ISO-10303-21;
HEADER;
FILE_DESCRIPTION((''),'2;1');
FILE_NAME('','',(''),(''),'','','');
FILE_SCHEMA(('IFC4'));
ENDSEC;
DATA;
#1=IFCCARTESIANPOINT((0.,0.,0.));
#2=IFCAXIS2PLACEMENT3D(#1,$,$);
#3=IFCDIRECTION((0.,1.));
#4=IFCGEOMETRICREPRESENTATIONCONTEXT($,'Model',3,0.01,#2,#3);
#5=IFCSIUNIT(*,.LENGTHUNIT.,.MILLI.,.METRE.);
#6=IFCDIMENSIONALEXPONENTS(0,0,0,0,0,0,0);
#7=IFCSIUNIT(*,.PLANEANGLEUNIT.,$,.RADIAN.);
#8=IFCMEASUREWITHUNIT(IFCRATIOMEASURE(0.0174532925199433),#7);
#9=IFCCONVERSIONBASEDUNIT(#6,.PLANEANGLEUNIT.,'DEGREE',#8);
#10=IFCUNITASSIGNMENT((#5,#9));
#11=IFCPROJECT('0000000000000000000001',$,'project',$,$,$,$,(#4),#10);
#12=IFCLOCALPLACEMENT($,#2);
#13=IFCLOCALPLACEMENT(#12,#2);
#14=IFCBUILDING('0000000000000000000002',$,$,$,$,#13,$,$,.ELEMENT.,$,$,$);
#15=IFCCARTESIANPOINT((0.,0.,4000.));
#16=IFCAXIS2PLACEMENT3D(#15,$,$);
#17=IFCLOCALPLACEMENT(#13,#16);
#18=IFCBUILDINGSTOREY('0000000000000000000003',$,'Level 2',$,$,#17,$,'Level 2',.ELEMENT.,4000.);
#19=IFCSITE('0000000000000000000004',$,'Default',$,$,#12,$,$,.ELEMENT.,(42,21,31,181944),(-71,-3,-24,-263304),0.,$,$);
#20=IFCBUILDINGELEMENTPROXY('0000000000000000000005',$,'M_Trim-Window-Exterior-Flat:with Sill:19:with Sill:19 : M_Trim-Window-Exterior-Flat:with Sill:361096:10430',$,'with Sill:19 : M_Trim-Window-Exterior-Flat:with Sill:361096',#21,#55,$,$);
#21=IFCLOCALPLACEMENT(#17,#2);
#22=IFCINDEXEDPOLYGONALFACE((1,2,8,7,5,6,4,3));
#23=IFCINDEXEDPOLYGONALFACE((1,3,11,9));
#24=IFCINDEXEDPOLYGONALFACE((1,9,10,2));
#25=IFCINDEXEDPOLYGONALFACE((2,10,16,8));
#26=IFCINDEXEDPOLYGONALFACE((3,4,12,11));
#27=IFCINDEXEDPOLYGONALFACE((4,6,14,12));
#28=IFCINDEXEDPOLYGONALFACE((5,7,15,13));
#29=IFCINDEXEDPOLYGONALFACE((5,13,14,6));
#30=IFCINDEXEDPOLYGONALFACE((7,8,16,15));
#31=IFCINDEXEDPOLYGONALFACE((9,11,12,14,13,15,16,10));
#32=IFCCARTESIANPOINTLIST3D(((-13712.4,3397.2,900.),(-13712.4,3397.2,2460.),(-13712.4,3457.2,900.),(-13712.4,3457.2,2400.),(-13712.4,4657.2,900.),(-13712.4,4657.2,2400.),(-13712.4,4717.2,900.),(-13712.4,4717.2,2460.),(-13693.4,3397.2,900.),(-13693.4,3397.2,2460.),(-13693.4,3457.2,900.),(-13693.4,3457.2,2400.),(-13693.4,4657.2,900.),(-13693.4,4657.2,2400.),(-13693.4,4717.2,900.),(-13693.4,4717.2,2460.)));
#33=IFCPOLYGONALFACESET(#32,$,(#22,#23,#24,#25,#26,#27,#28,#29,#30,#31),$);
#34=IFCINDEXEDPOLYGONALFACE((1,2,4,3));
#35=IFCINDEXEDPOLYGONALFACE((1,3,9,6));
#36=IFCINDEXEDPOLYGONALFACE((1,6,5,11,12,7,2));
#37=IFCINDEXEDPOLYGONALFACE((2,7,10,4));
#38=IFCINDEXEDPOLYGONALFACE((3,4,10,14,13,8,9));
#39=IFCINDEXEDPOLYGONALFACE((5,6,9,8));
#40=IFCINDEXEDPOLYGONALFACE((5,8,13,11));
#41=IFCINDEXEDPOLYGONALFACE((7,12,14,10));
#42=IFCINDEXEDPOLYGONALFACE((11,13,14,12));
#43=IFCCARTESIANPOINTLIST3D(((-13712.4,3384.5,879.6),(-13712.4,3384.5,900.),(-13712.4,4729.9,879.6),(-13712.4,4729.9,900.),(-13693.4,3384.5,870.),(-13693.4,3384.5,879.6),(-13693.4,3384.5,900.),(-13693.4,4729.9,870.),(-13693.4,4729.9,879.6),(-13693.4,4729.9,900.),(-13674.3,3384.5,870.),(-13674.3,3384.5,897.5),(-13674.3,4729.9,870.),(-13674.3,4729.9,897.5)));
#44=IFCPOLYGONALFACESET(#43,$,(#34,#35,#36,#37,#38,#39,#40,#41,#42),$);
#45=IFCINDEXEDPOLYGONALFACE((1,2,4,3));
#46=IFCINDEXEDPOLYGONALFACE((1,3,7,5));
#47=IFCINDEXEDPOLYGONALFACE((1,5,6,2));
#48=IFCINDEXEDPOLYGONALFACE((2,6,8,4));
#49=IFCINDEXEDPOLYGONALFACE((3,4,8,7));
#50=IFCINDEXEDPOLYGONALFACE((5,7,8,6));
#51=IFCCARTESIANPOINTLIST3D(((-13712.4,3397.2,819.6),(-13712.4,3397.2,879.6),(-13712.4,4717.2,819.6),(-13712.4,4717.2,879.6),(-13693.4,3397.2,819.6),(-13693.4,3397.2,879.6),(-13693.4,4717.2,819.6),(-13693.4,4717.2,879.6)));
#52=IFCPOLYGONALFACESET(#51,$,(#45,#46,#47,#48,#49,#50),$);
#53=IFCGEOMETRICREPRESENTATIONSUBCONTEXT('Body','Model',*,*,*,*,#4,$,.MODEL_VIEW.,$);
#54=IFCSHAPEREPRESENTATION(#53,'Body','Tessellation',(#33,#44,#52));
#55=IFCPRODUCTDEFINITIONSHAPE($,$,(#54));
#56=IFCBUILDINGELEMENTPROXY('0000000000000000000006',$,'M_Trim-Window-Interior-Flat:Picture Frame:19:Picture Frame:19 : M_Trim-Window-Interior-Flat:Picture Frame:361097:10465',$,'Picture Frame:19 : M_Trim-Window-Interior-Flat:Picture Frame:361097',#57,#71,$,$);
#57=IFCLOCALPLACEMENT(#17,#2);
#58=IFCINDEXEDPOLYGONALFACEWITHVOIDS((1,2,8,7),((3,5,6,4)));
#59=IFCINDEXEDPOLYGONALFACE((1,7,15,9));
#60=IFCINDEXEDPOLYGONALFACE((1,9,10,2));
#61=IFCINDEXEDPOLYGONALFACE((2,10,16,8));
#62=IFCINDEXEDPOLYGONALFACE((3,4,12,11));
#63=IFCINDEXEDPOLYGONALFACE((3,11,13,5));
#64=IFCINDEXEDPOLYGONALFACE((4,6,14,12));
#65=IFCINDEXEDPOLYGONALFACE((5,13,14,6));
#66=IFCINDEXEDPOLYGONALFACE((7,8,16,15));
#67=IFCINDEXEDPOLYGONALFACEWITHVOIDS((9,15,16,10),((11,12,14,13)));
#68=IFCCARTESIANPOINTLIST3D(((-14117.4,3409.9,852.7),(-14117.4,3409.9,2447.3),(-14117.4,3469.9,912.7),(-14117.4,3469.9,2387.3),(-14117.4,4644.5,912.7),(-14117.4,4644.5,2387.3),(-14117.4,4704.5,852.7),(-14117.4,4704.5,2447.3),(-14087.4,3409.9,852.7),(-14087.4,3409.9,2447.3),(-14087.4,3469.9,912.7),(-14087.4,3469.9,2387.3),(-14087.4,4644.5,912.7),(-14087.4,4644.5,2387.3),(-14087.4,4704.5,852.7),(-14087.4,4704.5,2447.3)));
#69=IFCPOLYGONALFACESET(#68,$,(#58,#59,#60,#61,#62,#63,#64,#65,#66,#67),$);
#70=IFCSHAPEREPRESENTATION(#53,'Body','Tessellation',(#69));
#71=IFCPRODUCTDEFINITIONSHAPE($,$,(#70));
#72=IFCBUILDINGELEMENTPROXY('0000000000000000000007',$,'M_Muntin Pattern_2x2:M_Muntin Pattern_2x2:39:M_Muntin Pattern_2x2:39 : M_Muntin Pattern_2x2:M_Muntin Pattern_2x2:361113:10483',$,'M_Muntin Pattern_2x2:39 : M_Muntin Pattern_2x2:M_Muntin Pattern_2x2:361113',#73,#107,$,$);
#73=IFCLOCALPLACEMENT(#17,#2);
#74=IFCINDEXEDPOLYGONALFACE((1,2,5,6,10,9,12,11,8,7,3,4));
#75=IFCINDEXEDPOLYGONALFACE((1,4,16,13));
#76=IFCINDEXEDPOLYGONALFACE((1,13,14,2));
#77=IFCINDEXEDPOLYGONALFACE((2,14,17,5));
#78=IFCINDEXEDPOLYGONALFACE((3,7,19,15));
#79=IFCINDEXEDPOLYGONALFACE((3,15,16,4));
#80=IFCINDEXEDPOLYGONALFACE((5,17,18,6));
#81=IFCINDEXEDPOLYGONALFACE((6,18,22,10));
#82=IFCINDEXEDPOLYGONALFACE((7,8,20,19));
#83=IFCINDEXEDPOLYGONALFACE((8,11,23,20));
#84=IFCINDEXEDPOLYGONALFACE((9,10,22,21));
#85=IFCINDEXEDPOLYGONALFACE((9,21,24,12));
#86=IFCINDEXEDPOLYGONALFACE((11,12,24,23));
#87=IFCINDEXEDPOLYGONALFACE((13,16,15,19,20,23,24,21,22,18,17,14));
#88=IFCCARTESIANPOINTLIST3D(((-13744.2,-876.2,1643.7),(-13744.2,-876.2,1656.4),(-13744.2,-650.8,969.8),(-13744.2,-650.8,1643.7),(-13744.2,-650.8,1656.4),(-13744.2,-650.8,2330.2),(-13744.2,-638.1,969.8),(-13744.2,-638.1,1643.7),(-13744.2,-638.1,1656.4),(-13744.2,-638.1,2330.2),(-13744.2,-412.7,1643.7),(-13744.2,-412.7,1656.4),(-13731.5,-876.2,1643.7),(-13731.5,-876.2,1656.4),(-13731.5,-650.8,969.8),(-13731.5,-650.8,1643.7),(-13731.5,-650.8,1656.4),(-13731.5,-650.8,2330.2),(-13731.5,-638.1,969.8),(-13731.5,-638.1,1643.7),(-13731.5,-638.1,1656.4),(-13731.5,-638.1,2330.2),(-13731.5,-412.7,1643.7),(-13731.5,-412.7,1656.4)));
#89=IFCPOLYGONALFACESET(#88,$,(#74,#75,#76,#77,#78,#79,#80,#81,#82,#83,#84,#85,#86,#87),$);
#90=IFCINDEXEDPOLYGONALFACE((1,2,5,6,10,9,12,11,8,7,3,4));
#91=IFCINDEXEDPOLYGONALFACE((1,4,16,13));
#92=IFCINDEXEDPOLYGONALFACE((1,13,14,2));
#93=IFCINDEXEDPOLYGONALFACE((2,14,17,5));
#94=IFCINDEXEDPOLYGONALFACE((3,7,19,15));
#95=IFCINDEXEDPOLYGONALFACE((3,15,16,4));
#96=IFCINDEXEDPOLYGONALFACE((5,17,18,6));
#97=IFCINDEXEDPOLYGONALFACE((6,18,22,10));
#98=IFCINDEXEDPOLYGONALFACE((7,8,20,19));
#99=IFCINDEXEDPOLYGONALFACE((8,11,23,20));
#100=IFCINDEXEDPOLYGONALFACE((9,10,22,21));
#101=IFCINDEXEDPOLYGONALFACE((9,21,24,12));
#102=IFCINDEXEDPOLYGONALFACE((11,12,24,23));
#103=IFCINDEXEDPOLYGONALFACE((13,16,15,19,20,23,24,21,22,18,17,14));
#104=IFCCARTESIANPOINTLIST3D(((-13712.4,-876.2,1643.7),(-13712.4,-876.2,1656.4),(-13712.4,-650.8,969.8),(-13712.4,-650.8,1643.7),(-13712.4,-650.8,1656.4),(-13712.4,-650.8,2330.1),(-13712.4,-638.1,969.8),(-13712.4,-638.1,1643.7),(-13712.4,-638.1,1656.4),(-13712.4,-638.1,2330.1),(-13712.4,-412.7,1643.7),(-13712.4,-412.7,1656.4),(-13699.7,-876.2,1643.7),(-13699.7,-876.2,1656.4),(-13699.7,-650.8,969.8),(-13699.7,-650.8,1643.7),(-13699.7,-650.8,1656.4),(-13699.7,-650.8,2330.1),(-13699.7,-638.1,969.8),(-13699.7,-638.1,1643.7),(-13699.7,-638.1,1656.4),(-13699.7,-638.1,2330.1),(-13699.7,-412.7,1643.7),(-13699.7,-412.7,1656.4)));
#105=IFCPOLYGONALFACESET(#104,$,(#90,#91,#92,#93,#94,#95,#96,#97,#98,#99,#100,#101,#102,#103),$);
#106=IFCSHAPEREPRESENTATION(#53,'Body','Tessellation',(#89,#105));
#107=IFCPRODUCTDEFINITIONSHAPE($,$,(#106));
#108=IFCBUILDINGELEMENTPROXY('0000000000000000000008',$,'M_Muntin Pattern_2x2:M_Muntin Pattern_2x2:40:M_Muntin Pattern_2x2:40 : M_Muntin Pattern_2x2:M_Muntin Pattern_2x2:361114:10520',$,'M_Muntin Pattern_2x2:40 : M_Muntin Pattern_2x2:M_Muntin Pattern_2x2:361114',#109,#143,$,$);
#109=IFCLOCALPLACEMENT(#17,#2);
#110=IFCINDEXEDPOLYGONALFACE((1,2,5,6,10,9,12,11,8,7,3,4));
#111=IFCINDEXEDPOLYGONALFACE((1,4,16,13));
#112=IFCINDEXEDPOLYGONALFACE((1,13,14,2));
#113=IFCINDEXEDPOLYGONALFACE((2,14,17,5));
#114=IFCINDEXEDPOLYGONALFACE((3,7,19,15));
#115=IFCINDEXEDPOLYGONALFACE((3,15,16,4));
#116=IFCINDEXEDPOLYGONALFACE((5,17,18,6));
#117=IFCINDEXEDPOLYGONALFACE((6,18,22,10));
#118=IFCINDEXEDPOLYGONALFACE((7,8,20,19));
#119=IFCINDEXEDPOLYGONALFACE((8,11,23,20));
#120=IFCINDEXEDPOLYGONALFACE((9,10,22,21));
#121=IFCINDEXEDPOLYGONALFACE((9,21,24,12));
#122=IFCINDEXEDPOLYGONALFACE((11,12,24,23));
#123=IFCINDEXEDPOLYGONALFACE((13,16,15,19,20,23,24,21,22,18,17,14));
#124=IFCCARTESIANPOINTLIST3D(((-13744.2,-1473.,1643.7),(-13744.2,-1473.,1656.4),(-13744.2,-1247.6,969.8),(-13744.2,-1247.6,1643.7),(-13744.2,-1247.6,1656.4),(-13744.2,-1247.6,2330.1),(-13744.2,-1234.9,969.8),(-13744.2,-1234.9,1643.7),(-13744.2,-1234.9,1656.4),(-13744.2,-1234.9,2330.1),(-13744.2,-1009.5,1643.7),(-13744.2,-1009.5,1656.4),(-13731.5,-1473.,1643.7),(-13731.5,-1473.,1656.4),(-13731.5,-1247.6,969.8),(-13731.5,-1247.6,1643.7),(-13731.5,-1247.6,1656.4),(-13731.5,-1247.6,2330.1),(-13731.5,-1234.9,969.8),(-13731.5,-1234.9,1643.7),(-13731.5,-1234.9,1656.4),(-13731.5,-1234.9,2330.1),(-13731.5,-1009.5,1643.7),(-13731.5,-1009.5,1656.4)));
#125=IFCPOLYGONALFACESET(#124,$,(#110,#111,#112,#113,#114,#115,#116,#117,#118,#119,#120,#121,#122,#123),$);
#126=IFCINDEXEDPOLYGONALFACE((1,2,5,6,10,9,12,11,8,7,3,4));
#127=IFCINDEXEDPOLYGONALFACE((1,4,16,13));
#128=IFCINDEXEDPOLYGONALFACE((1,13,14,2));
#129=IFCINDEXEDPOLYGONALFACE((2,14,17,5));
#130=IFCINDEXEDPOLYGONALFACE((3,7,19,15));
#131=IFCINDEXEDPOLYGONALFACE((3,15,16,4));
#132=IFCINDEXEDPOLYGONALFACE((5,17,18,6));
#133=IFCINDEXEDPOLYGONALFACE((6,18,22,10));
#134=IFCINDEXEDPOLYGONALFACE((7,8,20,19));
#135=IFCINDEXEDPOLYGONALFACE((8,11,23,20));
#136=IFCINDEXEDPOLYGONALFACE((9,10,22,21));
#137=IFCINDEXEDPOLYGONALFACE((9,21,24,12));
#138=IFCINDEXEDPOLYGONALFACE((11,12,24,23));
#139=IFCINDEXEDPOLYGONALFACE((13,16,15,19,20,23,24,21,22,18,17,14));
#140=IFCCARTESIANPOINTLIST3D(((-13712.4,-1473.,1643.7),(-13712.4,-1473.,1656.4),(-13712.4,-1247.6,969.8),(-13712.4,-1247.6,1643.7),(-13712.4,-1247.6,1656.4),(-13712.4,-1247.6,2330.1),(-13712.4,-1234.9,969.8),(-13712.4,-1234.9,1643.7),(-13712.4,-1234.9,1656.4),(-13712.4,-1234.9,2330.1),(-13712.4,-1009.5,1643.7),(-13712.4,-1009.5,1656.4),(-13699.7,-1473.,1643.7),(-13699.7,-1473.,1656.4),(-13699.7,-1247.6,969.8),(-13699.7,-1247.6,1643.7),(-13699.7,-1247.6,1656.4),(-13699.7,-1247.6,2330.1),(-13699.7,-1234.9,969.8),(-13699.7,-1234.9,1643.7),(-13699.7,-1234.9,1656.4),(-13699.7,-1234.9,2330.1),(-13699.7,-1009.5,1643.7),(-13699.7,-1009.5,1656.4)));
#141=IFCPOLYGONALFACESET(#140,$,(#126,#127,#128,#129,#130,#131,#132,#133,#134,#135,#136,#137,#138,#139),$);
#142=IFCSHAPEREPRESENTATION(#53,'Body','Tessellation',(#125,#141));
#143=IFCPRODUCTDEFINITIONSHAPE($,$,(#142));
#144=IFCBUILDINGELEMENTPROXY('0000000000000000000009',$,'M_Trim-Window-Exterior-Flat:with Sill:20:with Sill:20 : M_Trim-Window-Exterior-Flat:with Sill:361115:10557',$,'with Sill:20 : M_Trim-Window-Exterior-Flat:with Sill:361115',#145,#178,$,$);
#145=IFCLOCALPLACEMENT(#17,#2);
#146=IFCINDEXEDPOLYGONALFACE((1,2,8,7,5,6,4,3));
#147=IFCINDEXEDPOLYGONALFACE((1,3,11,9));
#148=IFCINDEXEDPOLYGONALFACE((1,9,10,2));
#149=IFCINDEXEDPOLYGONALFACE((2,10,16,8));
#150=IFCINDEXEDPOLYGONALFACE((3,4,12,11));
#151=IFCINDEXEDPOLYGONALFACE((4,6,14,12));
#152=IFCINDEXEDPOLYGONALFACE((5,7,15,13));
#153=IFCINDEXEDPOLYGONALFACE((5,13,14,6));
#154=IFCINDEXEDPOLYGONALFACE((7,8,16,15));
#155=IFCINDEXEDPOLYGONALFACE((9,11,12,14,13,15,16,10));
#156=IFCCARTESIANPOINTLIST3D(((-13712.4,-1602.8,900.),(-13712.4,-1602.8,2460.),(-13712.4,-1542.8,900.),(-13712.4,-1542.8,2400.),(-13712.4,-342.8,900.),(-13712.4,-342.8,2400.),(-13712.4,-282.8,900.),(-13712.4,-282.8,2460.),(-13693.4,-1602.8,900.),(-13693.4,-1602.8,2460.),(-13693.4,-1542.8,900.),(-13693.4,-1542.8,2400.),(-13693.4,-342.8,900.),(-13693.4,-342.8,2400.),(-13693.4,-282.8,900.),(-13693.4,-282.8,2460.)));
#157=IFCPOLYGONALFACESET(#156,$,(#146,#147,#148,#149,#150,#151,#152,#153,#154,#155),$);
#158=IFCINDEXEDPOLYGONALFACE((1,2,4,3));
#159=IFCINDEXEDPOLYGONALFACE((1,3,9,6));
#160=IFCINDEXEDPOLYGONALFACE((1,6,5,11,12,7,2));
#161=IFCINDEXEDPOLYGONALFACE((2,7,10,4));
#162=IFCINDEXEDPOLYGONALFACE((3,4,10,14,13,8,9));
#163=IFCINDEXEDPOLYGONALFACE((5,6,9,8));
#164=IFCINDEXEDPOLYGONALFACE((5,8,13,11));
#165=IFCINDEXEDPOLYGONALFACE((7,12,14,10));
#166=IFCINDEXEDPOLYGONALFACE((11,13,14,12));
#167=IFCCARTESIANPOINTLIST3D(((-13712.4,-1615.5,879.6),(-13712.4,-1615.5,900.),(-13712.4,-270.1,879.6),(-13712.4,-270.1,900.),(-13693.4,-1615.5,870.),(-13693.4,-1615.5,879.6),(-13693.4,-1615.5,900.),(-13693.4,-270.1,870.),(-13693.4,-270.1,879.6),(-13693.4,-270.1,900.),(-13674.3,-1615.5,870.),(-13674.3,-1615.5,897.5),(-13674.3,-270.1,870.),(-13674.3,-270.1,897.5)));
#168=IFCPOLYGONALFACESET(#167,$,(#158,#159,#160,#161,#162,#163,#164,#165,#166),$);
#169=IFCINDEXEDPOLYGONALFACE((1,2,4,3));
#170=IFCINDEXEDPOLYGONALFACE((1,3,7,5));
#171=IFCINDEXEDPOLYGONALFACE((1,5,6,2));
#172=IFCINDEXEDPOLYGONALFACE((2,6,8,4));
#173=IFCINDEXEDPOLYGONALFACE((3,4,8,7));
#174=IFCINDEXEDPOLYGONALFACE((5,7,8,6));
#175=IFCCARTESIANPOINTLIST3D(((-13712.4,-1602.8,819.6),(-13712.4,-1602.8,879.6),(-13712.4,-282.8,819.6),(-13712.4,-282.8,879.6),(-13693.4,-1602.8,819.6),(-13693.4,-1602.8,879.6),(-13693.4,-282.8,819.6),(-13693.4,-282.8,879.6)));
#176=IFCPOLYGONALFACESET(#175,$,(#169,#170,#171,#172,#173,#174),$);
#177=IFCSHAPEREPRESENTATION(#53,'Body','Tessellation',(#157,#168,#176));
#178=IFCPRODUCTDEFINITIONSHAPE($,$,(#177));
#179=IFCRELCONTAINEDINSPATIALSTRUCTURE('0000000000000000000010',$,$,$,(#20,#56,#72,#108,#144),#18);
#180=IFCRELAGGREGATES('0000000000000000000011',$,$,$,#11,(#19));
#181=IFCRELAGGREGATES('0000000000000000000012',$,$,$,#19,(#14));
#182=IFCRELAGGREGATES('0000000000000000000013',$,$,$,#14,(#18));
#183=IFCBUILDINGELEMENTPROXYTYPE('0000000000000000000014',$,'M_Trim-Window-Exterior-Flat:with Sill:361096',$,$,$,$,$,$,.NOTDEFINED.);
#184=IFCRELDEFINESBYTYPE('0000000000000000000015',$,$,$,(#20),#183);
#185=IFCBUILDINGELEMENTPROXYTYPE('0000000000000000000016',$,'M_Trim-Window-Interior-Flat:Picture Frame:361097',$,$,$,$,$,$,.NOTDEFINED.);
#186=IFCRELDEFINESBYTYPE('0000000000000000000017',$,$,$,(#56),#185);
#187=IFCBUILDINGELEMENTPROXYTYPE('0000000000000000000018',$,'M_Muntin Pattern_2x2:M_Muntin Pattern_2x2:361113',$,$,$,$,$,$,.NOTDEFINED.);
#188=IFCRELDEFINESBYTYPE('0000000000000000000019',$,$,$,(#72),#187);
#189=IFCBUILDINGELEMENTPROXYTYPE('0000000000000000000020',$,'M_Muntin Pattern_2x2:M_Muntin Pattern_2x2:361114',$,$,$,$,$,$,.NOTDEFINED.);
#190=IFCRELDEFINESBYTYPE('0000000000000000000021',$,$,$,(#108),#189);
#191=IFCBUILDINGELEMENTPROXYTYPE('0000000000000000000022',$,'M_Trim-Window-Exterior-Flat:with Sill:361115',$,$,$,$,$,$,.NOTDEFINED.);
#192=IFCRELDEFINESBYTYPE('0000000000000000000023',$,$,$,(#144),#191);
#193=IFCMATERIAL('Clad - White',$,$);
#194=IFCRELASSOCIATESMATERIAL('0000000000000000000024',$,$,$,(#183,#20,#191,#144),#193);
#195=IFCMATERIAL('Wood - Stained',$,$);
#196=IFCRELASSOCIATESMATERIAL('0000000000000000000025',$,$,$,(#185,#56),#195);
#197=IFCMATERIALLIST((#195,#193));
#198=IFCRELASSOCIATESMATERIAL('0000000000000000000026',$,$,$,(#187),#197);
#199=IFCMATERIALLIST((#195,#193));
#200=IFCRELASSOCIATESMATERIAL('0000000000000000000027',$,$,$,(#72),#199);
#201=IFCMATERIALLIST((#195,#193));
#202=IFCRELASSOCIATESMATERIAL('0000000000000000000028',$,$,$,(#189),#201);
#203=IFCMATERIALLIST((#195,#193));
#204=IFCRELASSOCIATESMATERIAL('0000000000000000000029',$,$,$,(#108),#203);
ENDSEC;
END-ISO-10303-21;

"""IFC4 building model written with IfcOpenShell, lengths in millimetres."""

from ifc_helpers import new_model, entity, si_unit, converted_unit, direction, frame, frame_2d, origin, origin_2d_with_axis, place, context, subcontext, project, spatial, polyline, rectangle, outline, extrude, source, transform, mapped, material, material_list, type_object, type_shapes, element, save


model = new_model("IFC4")

# Units and contexts
model_context = context("Model", 3, precision=0.01, world=origin(), true_north=direction((0.0, 1.0)))
body_context = subcontext(model_context, "Body", "Model", "MODEL_VIEW")
ifc_project = project(units=[si_unit("LENGTHUNIT", "METRE", prefix="MILLI"), converted_unit("PLANEANGLEUNIT", "DEGREE", entity("IfcRatioMeasure", 0.0174532925199433), si_unit("PLANEANGLEUNIT", "RADIAN"), dimensions=[0, 0, 0, 0, 0, 0, 0])], contexts=[model_context])

# Site, building, storey
site_placement = place(None, origin())
site = spatial("IfcSite", under=ifc_project, at=site_placement, Name="Default", CompositionType="ELEMENT", RefLatitude=(42, 21, 31, 181944), RefLongitude=(-71, -3, -24, -263304), RefElevation=0.0)
building_placement = place(site_placement, origin())
building = spatial("IfcBuilding", under=site, at=building_placement, CompositionType="ELEMENT")
storey_placement = place(building_placement, frame((0.0, 0.0, 4000.0)))
storey = spatial("IfcBuildingStorey", under=building, at=storey_placement, Name="Level 2", LongName="Level 2", CompositionType="ELEMENT", Elevation=4000.0)

# Building element proxies
ifc_material_1 = material(Name="Wood - Stained")
ifc_material_2 = material(Name="Clad - White")
building_element_proxy_type_1 = type_object("IfcBuildingElementProxyType", Name="M_Trim-Window-Exterior-Flat:with Sill:361096", PredefinedType="NOTDEFINED", material=ifc_material_2)
shared_shape_1 = source(origin(), body_context, "Body", "SweptSolid", [
    extrude(outline(polyline([(-660.0, -765.0), (-600.0, -765.0), (-600.0, 735.0), (600.0, 735.0), (600.0, -765.0), (660.0, -765.0), (660.0, 795.0), (-660.0, 795.0), (-660.0, -765.0)])), frame((-13712.4, 4057.2, 5665.0), z_axis=(1.0, 0.0, 0.0), x_axis=(0.0, 1.0, 0.0)), (0.0, 0.0, 1.0), 19.1),
    extrude(outline(polyline([(-15.2, 0.0), (-15.2, -19.0), (12.3, -19.0), (14.8, 0.0), (14.8, 19.0), (-5.7, 19.0), (-5.7, 0.0), (-15.2, 0.0)])), frame((-13693.4, 3384.5, 4885.2), z_axis=(0.0, -1.0, 0.0), x_axis=(0.0, 0.0, 1.0)), (0.0, 0.0, -1.0), 1345.4),
    extrude(rectangle(XDim=19.1, YDim=1320.0, at=frame_2d((0.0, 0.0), x_axis=(1.0, 0.0))), frame((-13702.9, 4057.2, 4819.6), z_axis=(0.0, 0.0, 1.0), x_axis=(-1.0, 0.0, 0.0)), (0.0, 0.0, 1.0), 60.0),
])
type_shapes(building_element_proxy_type_1, [shared_shape_1])
proxy_1_placement = place(storey_placement, frame((0.0, 0.0, -4000.0)))
element("IfcBuildingElementProxy", 1, at=proxy_1_placement, inside=storey, type_object=building_element_proxy_type_1, material=ifc_material_2, Name="M_Trim-Window-Exterior-Flat:with Sill:19:with Sill:19 : M_Trim-Window-Exterior-Flat:with Sill:361096:10430", ObjectType="with Sill:19 : M_Trim-Window-Exterior-Flat:with Sill:361096", context=body_context, shape_type="MappedRepresentation", body=[
    mapped(shared_shape_1, transform((0.0, 0.0, 0.0), scale=1.0)),
])
building_element_proxy_type_2 = type_object("IfcBuildingElementProxyType", Name="M_Trim-Window-Interior-Flat:Picture Frame:361097", PredefinedType="NOTDEFINED", material=ifc_material_1)
shared_shape_2 = source(origin(), body_context, "Body", "SweptSolid", [
    extrude(outline(polyline([(-647.3, -797.3), (647.3, -797.3), (647.3, 797.3), (-647.3, 797.3), (-647.3, -797.3)]), holes=[polyline([(587.3, 737.3), (587.3, -737.3), (-587.3, -737.3), (-587.3, 737.3), (587.3, 737.3)])]), frame((-14117.4, 4057.2, 5650.0), z_axis=(1.0, 0.0, 0.0), x_axis=(0.0, -1.0, 0.0)), (0.0, 0.0, 1.0), 30.0),
])
type_shapes(building_element_proxy_type_2, [shared_shape_2])
proxy_2_placement = place(storey_placement, frame((0.0, 0.0, -4000.0)))
element("IfcBuildingElementProxy", 2, at=proxy_2_placement, inside=storey, type_object=building_element_proxy_type_2, material=ifc_material_1, Name="M_Trim-Window-Interior-Flat:Picture Frame:19:Picture Frame:19 : M_Trim-Window-Interior-Flat:Picture Frame:361097:10465", ObjectType="Picture Frame:19 : M_Trim-Window-Interior-Flat:Picture Frame:361097", context=body_context, shape_type="MappedRepresentation", body=[
    mapped(shared_shape_2, transform((0.0, 0.0, 0.0), scale=1.0)),
])
ifc_material_list_1 = material_list([ifc_material_1, ifc_material_2])
ifc_material_list_2 = material_list([ifc_material_1, ifc_material_2])
building_element_proxy_type_3 = type_object("IfcBuildingElementProxyType", Name="M_Muntin Pattern_2x2:M_Muntin Pattern_2x2:361113", PredefinedType="NOTDEFINED", material=ifc_material_list_2)
shared_shape_3 = source(origin(), body_context, "Body", "SweptSolid", [
    extrude(outline(polyline([(-6.4, -680.2), (6.3, -680.2), (6.3, -6.4), (231.7, -6.4), (231.7, 6.3), (6.3, 6.3), (6.3, 680.2), (-6.4, 680.2), (-6.4, 6.3), (-231.7, 6.3), (-231.7, -6.4), (-6.4, -6.4), (-6.4, -680.2)])), frame((-13744.2, -644.4, 5650.0), z_axis=(1.0, 0.0, 0.0), x_axis=(0.0, -1.0, 0.0)), (0.0, 0.0, 1.0), 12.7),
    extrude(outline(polyline([(-6.4, -680.1), (6.3, -680.1), (6.3, -6.4), (231.7, -6.4), (231.7, 6.3), (6.3, 6.3), (6.3, 680.2), (-6.4, 680.2), (-6.4, 6.3), (-231.7, 6.3), (-231.7, -6.4), (-6.4, -6.4), (-6.4, -680.1)])), frame((-13712.4, -644.4, 5650.0), z_axis=(1.0, 0.0, 0.0), x_axis=(0.0, -1.0, 0.0)), (0.0, 0.0, 1.0), 12.7),
])
type_shapes(building_element_proxy_type_3, [shared_shape_3])
proxy_3_placement = place(storey_placement, frame((0.0, 0.0, -4000.0)))
element("IfcBuildingElementProxy", 3, at=proxy_3_placement, inside=storey, type_object=building_element_proxy_type_3, material=ifc_material_list_1, Name="M_Muntin Pattern_2x2:M_Muntin Pattern_2x2:39:M_Muntin Pattern_2x2:39 : M_Muntin Pattern_2x2:M_Muntin Pattern_2x2:361113:10483", ObjectType="M_Muntin Pattern_2x2:39 : M_Muntin Pattern_2x2:M_Muntin Pattern_2x2:361113", context=body_context, shape_type="MappedRepresentation", body=[
    mapped(shared_shape_3, transform((0.0, 0.0, 0.0), scale=1.0)),
])
ifc_material_list_3 = material_list([ifc_material_1, ifc_material_2])
ifc_material_list_4 = material_list([ifc_material_1, ifc_material_2])
building_element_proxy_type_4 = type_object("IfcBuildingElementProxyType", Name="M_Muntin Pattern_2x2:M_Muntin Pattern_2x2:361114", PredefinedType="NOTDEFINED", material=ifc_material_list_4)
shared_shape_4 = source(origin(), body_context, "Body", "SweptSolid", [
    extrude(outline(polyline([(-680.1, 6.4), (-680.1, -6.3), (-6.4, -6.3), (-6.4, -231.7), (6.3, -231.7), (6.3, -6.3), (680.2, -6.3), (680.2, 6.4), (6.3, 6.4), (6.3, 231.7), (-6.4, 231.7), (-6.4, 6.4), (-680.1, 6.4)])), frame((-13744.2, -1241.3, 5650.0), z_axis=(-1.0, 0.0, 0.0), x_axis=(0.0, 0.0, -1.0)), (0.0, 0.0, -1.0), 12.7),
    extrude(outline(polyline([(-680.1, 6.4), (-680.1, -6.3), (-6.4, -6.3), (-6.4, -231.7), (6.3, -231.7), (6.3, -6.3), (680.2, -6.3), (680.2, 6.4), (6.3, 6.4), (6.3, 231.7), (-6.4, 231.7), (-6.4, 6.4), (-680.1, 6.4)])), frame((-13712.4, -1241.3, 5650.0), z_axis=(-1.0, 0.0, 0.0), x_axis=(0.0, 0.0, -1.0)), (0.0, 0.0, -1.0), 12.7),
])
type_shapes(building_element_proxy_type_4, [shared_shape_4])
proxy_4_placement = place(storey_placement, frame((0.0, 0.0, -4000.0)))
element("IfcBuildingElementProxy", 4, at=proxy_4_placement, inside=storey, type_object=building_element_proxy_type_4, material=ifc_material_list_3, Name="M_Muntin Pattern_2x2:M_Muntin Pattern_2x2:40:M_Muntin Pattern_2x2:40 : M_Muntin Pattern_2x2:M_Muntin Pattern_2x2:361114:10520", ObjectType="M_Muntin Pattern_2x2:40 : M_Muntin Pattern_2x2:M_Muntin Pattern_2x2:361114", context=body_context, shape_type="MappedRepresentation", body=[
    mapped(shared_shape_4, transform((0.0, 0.0, 0.0), scale=1.0)),
])
building_element_proxy_type_5 = type_object("IfcBuildingElementProxyType", Name="M_Trim-Window-Exterior-Flat:with Sill:361115", PredefinedType="NOTDEFINED", material=ifc_material_2)
shared_shape_5 = source(origin(), body_context, "Body", "SweptSolid", [
    extrude(outline(polyline([(-660.0, -765.0), (-600.0, -765.0), (-600.0, 735.0), (600.0, 735.0), (600.0, -765.0), (660.0, -765.0), (660.0, 795.0), (-660.0, 795.0), (-660.0, -765.0)])), frame((-13712.4, -942.8, 5665.0), z_axis=(1.0, 0.0, 0.0), x_axis=(0.0, 1.0, 0.0)), (0.0, 0.0, 1.0), 19.1),
    extrude(outline(polyline([(-15.2, 0.0), (-15.2, -19.0), (12.3, -19.0), (14.8, 0.0), (14.8, 19.0), (-5.7, 19.0), (-5.7, 0.0), (-15.2, 0.0)])), frame((-13693.4, -1615.5, 4885.2), z_axis=(0.0, -1.0, 0.0), x_axis=(0.0, 0.0, 1.0)), (0.0, 0.0, -1.0), 1345.4),
    extrude(rectangle(XDim=19.1, YDim=1320.0, at=origin_2d_with_axis()), frame((-13702.9, -942.8, 4819.6), z_axis=(0.0, 0.0, 1.0), x_axis=(-1.0, 0.0, 0.0)), (0.0, 0.0, 1.0), 60.0),
])
type_shapes(building_element_proxy_type_5, [shared_shape_5])
proxy_5_placement = place(storey_placement, frame((0.0, 0.0, -4000.0)))
element("IfcBuildingElementProxy", 5, at=proxy_5_placement, inside=storey, type_object=building_element_proxy_type_5, material=ifc_material_2, Name="M_Trim-Window-Exterior-Flat:with Sill:20:with Sill:20 : M_Trim-Window-Exterior-Flat:with Sill:361115:10557", ObjectType="with Sill:20 : M_Trim-Window-Exterior-Flat:with Sill:361115", context=body_context, shape_type="MappedRepresentation", body=[
    mapped(shared_shape_5, transform((0.0, 0.0, 0.0), scale=1.0)),
])

save(model, "model.ifc")
